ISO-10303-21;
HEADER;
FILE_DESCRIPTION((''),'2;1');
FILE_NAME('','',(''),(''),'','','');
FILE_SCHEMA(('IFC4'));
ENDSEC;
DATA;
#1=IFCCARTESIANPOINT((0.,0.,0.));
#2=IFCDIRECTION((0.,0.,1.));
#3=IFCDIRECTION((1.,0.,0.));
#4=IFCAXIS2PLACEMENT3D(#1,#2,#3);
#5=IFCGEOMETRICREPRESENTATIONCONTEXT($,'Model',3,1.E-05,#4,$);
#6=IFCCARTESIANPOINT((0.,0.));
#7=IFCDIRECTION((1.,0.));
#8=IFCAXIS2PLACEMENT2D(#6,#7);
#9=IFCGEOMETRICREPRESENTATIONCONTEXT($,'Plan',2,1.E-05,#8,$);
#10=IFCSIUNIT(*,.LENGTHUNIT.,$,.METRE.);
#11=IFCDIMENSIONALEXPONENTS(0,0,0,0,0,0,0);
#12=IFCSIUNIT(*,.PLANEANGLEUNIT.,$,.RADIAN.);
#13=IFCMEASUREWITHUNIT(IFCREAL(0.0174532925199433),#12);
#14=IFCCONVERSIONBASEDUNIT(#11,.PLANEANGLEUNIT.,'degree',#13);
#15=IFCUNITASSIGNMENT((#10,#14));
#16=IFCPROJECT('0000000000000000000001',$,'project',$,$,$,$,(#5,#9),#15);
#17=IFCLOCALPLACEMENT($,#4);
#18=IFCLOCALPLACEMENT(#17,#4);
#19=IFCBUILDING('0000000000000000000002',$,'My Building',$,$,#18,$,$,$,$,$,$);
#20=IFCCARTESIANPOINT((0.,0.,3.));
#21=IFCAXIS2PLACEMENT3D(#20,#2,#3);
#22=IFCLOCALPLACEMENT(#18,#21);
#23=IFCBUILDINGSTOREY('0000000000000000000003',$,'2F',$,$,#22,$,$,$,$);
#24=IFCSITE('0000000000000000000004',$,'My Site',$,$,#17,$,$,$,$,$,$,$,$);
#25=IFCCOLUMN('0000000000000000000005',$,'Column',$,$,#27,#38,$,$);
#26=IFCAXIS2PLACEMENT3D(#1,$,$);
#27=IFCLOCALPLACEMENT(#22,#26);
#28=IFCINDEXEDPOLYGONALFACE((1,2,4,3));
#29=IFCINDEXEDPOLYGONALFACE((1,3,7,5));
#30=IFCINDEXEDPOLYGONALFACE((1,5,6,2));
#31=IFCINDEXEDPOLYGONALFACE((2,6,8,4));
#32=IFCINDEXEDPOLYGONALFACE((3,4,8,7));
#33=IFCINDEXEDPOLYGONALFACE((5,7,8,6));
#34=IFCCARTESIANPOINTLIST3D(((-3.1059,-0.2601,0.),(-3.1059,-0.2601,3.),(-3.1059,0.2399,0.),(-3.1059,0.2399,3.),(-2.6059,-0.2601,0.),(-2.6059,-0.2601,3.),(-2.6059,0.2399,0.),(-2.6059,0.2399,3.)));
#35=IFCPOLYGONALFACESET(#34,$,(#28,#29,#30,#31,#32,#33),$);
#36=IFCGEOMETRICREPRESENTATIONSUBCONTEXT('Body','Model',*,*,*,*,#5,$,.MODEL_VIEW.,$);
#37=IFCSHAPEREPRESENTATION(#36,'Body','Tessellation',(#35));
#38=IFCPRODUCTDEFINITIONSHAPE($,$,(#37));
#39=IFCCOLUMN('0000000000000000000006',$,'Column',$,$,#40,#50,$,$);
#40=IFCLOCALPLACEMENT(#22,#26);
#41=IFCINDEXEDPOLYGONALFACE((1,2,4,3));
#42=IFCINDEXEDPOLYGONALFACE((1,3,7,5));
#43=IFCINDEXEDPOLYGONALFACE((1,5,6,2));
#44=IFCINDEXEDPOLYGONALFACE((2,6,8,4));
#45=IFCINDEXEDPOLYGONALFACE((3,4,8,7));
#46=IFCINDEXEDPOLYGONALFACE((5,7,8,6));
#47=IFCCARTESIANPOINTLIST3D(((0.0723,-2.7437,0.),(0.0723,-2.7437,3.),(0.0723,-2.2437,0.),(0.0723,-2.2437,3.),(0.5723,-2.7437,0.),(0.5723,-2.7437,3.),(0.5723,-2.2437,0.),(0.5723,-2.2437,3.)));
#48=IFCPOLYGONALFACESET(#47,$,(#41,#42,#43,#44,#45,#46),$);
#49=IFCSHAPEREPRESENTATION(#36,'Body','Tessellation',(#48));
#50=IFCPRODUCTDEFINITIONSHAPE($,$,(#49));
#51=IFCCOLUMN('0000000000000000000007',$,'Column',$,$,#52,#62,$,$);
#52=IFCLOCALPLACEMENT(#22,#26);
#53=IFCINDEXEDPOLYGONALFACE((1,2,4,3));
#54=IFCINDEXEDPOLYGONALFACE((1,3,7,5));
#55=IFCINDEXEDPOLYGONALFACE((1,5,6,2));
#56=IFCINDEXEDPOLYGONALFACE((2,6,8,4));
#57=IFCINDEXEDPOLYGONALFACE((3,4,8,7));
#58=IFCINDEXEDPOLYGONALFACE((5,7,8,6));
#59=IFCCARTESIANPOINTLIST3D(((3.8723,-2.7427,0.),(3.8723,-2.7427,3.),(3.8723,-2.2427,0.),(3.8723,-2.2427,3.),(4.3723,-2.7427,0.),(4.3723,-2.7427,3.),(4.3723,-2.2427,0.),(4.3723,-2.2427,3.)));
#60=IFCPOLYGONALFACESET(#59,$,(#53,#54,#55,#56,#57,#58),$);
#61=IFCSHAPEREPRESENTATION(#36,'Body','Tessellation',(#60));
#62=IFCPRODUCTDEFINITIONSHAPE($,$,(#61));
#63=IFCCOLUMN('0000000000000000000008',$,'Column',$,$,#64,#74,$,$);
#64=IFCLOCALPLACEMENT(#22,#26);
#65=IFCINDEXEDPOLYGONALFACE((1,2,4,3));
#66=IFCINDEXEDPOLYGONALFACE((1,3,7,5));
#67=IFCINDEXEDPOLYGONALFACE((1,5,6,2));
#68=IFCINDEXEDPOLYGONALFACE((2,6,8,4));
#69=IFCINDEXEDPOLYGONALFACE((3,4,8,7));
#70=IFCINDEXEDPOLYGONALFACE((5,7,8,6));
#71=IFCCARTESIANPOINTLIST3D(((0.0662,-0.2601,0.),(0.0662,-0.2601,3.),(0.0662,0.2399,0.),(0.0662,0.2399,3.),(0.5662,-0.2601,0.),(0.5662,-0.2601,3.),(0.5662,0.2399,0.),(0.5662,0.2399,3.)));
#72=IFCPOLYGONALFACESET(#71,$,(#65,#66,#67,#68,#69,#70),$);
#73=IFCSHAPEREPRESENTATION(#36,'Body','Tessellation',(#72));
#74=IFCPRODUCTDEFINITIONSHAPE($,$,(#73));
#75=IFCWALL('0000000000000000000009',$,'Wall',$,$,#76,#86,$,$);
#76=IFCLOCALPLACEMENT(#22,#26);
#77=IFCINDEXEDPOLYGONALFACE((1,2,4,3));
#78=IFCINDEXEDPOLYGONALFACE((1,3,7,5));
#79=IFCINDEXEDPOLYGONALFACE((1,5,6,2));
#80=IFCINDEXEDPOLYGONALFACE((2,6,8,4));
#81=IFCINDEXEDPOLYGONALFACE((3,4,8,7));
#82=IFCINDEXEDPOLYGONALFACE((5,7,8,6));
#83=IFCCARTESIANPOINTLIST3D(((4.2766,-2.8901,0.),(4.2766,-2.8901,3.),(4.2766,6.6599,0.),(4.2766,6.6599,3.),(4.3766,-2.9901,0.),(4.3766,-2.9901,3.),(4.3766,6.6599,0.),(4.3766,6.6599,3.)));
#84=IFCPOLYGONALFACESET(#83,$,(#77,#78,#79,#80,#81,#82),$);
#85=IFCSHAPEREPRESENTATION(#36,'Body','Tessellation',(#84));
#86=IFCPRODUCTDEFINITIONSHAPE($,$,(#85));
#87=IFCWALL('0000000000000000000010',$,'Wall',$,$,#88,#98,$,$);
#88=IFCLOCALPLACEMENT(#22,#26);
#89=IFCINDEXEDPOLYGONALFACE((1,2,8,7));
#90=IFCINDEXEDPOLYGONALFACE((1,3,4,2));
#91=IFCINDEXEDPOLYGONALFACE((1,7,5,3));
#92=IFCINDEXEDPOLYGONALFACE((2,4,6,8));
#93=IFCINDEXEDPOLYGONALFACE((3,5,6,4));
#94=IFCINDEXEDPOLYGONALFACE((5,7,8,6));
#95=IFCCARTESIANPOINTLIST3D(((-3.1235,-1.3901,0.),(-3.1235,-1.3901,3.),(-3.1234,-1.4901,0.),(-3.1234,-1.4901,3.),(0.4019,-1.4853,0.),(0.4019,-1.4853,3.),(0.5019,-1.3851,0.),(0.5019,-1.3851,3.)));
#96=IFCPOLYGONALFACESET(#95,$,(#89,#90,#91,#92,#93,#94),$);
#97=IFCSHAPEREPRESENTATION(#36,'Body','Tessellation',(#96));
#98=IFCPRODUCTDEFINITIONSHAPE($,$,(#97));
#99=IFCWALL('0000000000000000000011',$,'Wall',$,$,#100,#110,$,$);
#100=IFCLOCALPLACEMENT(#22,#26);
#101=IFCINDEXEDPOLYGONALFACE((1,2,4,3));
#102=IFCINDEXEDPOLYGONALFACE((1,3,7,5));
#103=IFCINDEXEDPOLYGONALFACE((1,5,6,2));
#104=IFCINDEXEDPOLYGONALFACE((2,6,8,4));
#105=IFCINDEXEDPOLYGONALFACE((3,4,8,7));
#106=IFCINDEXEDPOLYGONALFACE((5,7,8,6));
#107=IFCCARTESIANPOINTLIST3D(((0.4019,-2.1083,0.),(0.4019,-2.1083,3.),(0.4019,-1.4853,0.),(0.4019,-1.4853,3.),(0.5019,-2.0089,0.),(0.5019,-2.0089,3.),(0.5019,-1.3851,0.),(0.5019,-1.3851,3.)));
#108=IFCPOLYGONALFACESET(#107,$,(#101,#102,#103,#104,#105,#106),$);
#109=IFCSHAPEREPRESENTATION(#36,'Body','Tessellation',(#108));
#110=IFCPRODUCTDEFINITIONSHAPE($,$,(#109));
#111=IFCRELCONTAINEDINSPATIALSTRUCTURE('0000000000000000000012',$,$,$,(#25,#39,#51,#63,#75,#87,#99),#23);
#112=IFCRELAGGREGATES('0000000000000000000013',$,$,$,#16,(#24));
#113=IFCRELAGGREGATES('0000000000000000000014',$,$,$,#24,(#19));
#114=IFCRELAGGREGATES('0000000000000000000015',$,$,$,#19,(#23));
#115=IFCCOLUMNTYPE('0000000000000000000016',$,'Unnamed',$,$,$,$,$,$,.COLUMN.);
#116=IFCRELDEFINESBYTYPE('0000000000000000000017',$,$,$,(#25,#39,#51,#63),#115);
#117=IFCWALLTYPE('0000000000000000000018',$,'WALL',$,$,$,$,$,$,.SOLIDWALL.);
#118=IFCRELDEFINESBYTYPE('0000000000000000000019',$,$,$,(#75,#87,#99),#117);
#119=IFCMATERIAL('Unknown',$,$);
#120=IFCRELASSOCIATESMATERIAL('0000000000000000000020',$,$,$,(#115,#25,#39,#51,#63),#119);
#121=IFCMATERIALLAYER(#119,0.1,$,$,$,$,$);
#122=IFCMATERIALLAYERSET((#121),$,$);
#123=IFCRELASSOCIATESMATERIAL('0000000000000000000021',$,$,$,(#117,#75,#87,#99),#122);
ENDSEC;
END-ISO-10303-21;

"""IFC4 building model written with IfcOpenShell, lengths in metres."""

from ifc_helpers import new_model, entity, si_unit, converted_unit, frame, origin_with_axes, origin_2d_with_axis, place, context, subcontext, project, spatial, line, indexed_curve, rectangle, outline, extrude, material, layer, layer_set, layer_usage, material_profile, profile_set, profile_usage, type_object, element, save


model = new_model("IFC4")

# Units and contexts
model_context = context("Model", 3, precision=1e-05, world=origin_with_axes())
plan_context = context("Plan", 2, precision=1e-05, world=origin_2d_with_axis())
body_context_1 = subcontext(model_context, "Body", "Model", "MODEL_VIEW")
ifc_project = project(units=[si_unit("LENGTHUNIT", "METRE"), converted_unit("PLANEANGLEUNIT", "degree", entity("IfcReal", 0.0174532925199433), si_unit("PLANEANGLEUNIT", "RADIAN"), dimensions=[0, 0, 0, 0, 0, 0, 0])], contexts=[model_context, plan_context])

# Site, building, storey
site_placement = place(None, origin_with_axes())
site = spatial("IfcSite", under=ifc_project, at=site_placement, Name="My Site")
building_placement = place(site_placement, origin_with_axes())
building = spatial("IfcBuilding", under=site, at=building_placement, Name="My Building")
storey_placement = place(building_placement, frame((0.0, 0.0, 3.0), z_axis=(0.0, 0.0, 1.0), x_axis=(1.0, 0.0, 0.0)))
storey = spatial("IfcBuildingStorey", under=building, at=storey_placement, Name="2F")

# Columns
ifc_material = material(Name="Unknown")
ifc_material_profile = material_profile(ifc_material, rectangle(XDim=0.5, YDim=0.5))
ifc_profile_set = profile_set([ifc_material_profile])
ifc_profile_usage_1 = profile_usage(ifc_profile_set, cardinal=7)
column_type = type_object("IfcColumnType", Name="Unnamed", PredefinedType="COLUMN", material=ifc_profile_set)
column_1_placement = place(storey_placement, frame((-2.6059, 0.2399, 0.0), z_axis=(0.0, 0.0, 1.0), x_axis=(1.0, 0.0, 0.0)))
element("IfcColumn", 1, at=column_1_placement, inside=storey, type_object=column_type, material=ifc_profile_usage_1, Name="Column", context=body_context_1, shape_type="SweptSolid", body=[
    extrude(rectangle(XDim=0.5, YDim=0.5), frame((-0.25, -0.25, 0.0), z_axis=(0.0, 0.0, 1.0), x_axis=(1.0, 0.0, 0.0)), (0.0, 0.0, 1.0), 3.0),
])
ifc_profile_usage_2 = profile_usage(ifc_profile_set, cardinal=7)
column_2_placement = place(storey_placement, frame((0.5723, -2.2437, 0.0), z_axis=(0.0, 0.0, 1.0), x_axis=(1.0, 0.0, 0.0)))
element("IfcColumn", 2, at=column_2_placement, inside=storey, type_object=column_type, material=ifc_profile_usage_2, Name="Column", context=body_context_1, shape_type="SweptSolid", body=[
    extrude(rectangle(XDim=0.5, YDim=0.5), frame((-0.25, -0.25, 0.0), z_axis=(0.0, 0.0, 1.0), x_axis=(1.0, 0.0, 0.0)), (0.0, 0.0, 1.0), 3.0),
])
ifc_profile_usage_3 = profile_usage(ifc_profile_set, cardinal=7)
column_3_placement = place(storey_placement, frame((4.3723, -2.2427, 0.0), z_axis=(0.0, 0.0, 1.0), x_axis=(1.0, 0.0, 0.0)))
element("IfcColumn", 3, at=column_3_placement, inside=storey, type_object=column_type, material=ifc_profile_usage_3, Name="Column", context=body_context_1, shape_type="SweptSolid", body=[
    extrude(rectangle(XDim=0.5, YDim=0.5), frame((-0.25, -0.25, 0.0), z_axis=(0.0, 0.0, 1.0), x_axis=(1.0, 0.0, 0.0)), (0.0, 0.0, 1.0), 3.0),
])
ifc_profile_usage_4 = profile_usage(ifc_profile_set, cardinal=1)
column_4_placement = place(storey_placement, frame((0.5662, -0.2601, 0.0), z_axis=(0.0, 0.0, 1.0), x_axis=(1.0, 0.0, 0.0)))
element("IfcColumn", 4, at=column_4_placement, inside=storey, type_object=column_type, material=ifc_profile_usage_4, Name="Column", context=body_context_1, shape_type="SweptSolid", body=[
    extrude(rectangle(XDim=0.5, YDim=0.5), frame((-0.25, 0.25, 0.0), z_axis=(0.0, 0.0, 1.0), x_axis=(1.0, 0.0, 0.0)), (0.0, 0.0, 1.0), 3.0),
])

# Walls
ifc_layer = layer(ifc_material, 0.1)
ifc_layer_set = layer_set([ifc_layer])
ifc_layer_usage_1 = layer_usage(ifc_layer_set, "AXIS2", "POSITIVE", 0.0)
wall_type = type_object("IfcWallType", Name="WALL", PredefinedType="SOLIDWALL", material=ifc_layer_set)
wall_1_placement = place(storey_placement, frame((4.3766, -2.9901, 0.0), z_axis=(0.0, 0.0, 1.0), x_axis=(0.0, 1.0, 0.0)))
element("IfcWall", 5, at=wall_1_placement, inside=storey, type_object=wall_type, material=ifc_layer_usage_1, Name="Wall", context=body_context_1, shape_type="SweptSolid", body=[
    extrude(outline(indexed_curve([(0.0, 0.0), (0.1, 0.1), (9.65, 0.1), (9.65, 0.0)], segments=[line(1, 2, 3, 4, 1)])), origin_with_axes(), (0.0, 0.0, 1.0), 3.0),
])
ifc_layer_usage_2 = layer_usage(ifc_layer_set, "AXIS2", "POSITIVE", 0.0)
wall_2_placement = place(storey_placement, frame((-3.1234, -1.4901, 0.0), z_axis=(0.0, 0.0, 1.0), x_axis=(0.999999, 0.001371, 0.0)))
element("IfcWall", 6, at=wall_2_placement, inside=storey, type_object=wall_type, material=ifc_layer_usage_2, Name="Wall", context=body_context_1, shape_type="SweptSolid", body=[
    extrude(outline(indexed_curve([(0.0, 0.0), (0.0, 0.1), (3.6254, 0.1), (3.5253, 0.0)], segments=[line(1, 2, 3, 4, 1)])), origin_with_axes(), (0.0, 0.0, 1.0), 3.0),
])
ifc_layer_usage_3 = layer_usage(ifc_layer_set, "AXIS2", "POSITIVE", 0.0)
wall_3_placement = place(storey_placement, frame((0.4019, -1.4853, 0.0), z_axis=(0.0, 0.0, 1.0), x_axis=(0.0, -1.0, 0.0)))
element("IfcWall", 7, at=wall_3_placement, inside=storey, type_object=wall_type, material=ifc_layer_usage_3, Name="Wall", context=body_context_1, shape_type="SweptSolid", body=[
    extrude(outline(indexed_curve([(0.0, 0.0), (-0.1001, 0.1), (0.5237, 0.1), (0.623, 0.0)], segments=[line(1, 2, 3, 4, 1)])), origin_with_axes(), (0.0, 0.0, 1.0), 3.0),
])

save(model, "model.ifc")
